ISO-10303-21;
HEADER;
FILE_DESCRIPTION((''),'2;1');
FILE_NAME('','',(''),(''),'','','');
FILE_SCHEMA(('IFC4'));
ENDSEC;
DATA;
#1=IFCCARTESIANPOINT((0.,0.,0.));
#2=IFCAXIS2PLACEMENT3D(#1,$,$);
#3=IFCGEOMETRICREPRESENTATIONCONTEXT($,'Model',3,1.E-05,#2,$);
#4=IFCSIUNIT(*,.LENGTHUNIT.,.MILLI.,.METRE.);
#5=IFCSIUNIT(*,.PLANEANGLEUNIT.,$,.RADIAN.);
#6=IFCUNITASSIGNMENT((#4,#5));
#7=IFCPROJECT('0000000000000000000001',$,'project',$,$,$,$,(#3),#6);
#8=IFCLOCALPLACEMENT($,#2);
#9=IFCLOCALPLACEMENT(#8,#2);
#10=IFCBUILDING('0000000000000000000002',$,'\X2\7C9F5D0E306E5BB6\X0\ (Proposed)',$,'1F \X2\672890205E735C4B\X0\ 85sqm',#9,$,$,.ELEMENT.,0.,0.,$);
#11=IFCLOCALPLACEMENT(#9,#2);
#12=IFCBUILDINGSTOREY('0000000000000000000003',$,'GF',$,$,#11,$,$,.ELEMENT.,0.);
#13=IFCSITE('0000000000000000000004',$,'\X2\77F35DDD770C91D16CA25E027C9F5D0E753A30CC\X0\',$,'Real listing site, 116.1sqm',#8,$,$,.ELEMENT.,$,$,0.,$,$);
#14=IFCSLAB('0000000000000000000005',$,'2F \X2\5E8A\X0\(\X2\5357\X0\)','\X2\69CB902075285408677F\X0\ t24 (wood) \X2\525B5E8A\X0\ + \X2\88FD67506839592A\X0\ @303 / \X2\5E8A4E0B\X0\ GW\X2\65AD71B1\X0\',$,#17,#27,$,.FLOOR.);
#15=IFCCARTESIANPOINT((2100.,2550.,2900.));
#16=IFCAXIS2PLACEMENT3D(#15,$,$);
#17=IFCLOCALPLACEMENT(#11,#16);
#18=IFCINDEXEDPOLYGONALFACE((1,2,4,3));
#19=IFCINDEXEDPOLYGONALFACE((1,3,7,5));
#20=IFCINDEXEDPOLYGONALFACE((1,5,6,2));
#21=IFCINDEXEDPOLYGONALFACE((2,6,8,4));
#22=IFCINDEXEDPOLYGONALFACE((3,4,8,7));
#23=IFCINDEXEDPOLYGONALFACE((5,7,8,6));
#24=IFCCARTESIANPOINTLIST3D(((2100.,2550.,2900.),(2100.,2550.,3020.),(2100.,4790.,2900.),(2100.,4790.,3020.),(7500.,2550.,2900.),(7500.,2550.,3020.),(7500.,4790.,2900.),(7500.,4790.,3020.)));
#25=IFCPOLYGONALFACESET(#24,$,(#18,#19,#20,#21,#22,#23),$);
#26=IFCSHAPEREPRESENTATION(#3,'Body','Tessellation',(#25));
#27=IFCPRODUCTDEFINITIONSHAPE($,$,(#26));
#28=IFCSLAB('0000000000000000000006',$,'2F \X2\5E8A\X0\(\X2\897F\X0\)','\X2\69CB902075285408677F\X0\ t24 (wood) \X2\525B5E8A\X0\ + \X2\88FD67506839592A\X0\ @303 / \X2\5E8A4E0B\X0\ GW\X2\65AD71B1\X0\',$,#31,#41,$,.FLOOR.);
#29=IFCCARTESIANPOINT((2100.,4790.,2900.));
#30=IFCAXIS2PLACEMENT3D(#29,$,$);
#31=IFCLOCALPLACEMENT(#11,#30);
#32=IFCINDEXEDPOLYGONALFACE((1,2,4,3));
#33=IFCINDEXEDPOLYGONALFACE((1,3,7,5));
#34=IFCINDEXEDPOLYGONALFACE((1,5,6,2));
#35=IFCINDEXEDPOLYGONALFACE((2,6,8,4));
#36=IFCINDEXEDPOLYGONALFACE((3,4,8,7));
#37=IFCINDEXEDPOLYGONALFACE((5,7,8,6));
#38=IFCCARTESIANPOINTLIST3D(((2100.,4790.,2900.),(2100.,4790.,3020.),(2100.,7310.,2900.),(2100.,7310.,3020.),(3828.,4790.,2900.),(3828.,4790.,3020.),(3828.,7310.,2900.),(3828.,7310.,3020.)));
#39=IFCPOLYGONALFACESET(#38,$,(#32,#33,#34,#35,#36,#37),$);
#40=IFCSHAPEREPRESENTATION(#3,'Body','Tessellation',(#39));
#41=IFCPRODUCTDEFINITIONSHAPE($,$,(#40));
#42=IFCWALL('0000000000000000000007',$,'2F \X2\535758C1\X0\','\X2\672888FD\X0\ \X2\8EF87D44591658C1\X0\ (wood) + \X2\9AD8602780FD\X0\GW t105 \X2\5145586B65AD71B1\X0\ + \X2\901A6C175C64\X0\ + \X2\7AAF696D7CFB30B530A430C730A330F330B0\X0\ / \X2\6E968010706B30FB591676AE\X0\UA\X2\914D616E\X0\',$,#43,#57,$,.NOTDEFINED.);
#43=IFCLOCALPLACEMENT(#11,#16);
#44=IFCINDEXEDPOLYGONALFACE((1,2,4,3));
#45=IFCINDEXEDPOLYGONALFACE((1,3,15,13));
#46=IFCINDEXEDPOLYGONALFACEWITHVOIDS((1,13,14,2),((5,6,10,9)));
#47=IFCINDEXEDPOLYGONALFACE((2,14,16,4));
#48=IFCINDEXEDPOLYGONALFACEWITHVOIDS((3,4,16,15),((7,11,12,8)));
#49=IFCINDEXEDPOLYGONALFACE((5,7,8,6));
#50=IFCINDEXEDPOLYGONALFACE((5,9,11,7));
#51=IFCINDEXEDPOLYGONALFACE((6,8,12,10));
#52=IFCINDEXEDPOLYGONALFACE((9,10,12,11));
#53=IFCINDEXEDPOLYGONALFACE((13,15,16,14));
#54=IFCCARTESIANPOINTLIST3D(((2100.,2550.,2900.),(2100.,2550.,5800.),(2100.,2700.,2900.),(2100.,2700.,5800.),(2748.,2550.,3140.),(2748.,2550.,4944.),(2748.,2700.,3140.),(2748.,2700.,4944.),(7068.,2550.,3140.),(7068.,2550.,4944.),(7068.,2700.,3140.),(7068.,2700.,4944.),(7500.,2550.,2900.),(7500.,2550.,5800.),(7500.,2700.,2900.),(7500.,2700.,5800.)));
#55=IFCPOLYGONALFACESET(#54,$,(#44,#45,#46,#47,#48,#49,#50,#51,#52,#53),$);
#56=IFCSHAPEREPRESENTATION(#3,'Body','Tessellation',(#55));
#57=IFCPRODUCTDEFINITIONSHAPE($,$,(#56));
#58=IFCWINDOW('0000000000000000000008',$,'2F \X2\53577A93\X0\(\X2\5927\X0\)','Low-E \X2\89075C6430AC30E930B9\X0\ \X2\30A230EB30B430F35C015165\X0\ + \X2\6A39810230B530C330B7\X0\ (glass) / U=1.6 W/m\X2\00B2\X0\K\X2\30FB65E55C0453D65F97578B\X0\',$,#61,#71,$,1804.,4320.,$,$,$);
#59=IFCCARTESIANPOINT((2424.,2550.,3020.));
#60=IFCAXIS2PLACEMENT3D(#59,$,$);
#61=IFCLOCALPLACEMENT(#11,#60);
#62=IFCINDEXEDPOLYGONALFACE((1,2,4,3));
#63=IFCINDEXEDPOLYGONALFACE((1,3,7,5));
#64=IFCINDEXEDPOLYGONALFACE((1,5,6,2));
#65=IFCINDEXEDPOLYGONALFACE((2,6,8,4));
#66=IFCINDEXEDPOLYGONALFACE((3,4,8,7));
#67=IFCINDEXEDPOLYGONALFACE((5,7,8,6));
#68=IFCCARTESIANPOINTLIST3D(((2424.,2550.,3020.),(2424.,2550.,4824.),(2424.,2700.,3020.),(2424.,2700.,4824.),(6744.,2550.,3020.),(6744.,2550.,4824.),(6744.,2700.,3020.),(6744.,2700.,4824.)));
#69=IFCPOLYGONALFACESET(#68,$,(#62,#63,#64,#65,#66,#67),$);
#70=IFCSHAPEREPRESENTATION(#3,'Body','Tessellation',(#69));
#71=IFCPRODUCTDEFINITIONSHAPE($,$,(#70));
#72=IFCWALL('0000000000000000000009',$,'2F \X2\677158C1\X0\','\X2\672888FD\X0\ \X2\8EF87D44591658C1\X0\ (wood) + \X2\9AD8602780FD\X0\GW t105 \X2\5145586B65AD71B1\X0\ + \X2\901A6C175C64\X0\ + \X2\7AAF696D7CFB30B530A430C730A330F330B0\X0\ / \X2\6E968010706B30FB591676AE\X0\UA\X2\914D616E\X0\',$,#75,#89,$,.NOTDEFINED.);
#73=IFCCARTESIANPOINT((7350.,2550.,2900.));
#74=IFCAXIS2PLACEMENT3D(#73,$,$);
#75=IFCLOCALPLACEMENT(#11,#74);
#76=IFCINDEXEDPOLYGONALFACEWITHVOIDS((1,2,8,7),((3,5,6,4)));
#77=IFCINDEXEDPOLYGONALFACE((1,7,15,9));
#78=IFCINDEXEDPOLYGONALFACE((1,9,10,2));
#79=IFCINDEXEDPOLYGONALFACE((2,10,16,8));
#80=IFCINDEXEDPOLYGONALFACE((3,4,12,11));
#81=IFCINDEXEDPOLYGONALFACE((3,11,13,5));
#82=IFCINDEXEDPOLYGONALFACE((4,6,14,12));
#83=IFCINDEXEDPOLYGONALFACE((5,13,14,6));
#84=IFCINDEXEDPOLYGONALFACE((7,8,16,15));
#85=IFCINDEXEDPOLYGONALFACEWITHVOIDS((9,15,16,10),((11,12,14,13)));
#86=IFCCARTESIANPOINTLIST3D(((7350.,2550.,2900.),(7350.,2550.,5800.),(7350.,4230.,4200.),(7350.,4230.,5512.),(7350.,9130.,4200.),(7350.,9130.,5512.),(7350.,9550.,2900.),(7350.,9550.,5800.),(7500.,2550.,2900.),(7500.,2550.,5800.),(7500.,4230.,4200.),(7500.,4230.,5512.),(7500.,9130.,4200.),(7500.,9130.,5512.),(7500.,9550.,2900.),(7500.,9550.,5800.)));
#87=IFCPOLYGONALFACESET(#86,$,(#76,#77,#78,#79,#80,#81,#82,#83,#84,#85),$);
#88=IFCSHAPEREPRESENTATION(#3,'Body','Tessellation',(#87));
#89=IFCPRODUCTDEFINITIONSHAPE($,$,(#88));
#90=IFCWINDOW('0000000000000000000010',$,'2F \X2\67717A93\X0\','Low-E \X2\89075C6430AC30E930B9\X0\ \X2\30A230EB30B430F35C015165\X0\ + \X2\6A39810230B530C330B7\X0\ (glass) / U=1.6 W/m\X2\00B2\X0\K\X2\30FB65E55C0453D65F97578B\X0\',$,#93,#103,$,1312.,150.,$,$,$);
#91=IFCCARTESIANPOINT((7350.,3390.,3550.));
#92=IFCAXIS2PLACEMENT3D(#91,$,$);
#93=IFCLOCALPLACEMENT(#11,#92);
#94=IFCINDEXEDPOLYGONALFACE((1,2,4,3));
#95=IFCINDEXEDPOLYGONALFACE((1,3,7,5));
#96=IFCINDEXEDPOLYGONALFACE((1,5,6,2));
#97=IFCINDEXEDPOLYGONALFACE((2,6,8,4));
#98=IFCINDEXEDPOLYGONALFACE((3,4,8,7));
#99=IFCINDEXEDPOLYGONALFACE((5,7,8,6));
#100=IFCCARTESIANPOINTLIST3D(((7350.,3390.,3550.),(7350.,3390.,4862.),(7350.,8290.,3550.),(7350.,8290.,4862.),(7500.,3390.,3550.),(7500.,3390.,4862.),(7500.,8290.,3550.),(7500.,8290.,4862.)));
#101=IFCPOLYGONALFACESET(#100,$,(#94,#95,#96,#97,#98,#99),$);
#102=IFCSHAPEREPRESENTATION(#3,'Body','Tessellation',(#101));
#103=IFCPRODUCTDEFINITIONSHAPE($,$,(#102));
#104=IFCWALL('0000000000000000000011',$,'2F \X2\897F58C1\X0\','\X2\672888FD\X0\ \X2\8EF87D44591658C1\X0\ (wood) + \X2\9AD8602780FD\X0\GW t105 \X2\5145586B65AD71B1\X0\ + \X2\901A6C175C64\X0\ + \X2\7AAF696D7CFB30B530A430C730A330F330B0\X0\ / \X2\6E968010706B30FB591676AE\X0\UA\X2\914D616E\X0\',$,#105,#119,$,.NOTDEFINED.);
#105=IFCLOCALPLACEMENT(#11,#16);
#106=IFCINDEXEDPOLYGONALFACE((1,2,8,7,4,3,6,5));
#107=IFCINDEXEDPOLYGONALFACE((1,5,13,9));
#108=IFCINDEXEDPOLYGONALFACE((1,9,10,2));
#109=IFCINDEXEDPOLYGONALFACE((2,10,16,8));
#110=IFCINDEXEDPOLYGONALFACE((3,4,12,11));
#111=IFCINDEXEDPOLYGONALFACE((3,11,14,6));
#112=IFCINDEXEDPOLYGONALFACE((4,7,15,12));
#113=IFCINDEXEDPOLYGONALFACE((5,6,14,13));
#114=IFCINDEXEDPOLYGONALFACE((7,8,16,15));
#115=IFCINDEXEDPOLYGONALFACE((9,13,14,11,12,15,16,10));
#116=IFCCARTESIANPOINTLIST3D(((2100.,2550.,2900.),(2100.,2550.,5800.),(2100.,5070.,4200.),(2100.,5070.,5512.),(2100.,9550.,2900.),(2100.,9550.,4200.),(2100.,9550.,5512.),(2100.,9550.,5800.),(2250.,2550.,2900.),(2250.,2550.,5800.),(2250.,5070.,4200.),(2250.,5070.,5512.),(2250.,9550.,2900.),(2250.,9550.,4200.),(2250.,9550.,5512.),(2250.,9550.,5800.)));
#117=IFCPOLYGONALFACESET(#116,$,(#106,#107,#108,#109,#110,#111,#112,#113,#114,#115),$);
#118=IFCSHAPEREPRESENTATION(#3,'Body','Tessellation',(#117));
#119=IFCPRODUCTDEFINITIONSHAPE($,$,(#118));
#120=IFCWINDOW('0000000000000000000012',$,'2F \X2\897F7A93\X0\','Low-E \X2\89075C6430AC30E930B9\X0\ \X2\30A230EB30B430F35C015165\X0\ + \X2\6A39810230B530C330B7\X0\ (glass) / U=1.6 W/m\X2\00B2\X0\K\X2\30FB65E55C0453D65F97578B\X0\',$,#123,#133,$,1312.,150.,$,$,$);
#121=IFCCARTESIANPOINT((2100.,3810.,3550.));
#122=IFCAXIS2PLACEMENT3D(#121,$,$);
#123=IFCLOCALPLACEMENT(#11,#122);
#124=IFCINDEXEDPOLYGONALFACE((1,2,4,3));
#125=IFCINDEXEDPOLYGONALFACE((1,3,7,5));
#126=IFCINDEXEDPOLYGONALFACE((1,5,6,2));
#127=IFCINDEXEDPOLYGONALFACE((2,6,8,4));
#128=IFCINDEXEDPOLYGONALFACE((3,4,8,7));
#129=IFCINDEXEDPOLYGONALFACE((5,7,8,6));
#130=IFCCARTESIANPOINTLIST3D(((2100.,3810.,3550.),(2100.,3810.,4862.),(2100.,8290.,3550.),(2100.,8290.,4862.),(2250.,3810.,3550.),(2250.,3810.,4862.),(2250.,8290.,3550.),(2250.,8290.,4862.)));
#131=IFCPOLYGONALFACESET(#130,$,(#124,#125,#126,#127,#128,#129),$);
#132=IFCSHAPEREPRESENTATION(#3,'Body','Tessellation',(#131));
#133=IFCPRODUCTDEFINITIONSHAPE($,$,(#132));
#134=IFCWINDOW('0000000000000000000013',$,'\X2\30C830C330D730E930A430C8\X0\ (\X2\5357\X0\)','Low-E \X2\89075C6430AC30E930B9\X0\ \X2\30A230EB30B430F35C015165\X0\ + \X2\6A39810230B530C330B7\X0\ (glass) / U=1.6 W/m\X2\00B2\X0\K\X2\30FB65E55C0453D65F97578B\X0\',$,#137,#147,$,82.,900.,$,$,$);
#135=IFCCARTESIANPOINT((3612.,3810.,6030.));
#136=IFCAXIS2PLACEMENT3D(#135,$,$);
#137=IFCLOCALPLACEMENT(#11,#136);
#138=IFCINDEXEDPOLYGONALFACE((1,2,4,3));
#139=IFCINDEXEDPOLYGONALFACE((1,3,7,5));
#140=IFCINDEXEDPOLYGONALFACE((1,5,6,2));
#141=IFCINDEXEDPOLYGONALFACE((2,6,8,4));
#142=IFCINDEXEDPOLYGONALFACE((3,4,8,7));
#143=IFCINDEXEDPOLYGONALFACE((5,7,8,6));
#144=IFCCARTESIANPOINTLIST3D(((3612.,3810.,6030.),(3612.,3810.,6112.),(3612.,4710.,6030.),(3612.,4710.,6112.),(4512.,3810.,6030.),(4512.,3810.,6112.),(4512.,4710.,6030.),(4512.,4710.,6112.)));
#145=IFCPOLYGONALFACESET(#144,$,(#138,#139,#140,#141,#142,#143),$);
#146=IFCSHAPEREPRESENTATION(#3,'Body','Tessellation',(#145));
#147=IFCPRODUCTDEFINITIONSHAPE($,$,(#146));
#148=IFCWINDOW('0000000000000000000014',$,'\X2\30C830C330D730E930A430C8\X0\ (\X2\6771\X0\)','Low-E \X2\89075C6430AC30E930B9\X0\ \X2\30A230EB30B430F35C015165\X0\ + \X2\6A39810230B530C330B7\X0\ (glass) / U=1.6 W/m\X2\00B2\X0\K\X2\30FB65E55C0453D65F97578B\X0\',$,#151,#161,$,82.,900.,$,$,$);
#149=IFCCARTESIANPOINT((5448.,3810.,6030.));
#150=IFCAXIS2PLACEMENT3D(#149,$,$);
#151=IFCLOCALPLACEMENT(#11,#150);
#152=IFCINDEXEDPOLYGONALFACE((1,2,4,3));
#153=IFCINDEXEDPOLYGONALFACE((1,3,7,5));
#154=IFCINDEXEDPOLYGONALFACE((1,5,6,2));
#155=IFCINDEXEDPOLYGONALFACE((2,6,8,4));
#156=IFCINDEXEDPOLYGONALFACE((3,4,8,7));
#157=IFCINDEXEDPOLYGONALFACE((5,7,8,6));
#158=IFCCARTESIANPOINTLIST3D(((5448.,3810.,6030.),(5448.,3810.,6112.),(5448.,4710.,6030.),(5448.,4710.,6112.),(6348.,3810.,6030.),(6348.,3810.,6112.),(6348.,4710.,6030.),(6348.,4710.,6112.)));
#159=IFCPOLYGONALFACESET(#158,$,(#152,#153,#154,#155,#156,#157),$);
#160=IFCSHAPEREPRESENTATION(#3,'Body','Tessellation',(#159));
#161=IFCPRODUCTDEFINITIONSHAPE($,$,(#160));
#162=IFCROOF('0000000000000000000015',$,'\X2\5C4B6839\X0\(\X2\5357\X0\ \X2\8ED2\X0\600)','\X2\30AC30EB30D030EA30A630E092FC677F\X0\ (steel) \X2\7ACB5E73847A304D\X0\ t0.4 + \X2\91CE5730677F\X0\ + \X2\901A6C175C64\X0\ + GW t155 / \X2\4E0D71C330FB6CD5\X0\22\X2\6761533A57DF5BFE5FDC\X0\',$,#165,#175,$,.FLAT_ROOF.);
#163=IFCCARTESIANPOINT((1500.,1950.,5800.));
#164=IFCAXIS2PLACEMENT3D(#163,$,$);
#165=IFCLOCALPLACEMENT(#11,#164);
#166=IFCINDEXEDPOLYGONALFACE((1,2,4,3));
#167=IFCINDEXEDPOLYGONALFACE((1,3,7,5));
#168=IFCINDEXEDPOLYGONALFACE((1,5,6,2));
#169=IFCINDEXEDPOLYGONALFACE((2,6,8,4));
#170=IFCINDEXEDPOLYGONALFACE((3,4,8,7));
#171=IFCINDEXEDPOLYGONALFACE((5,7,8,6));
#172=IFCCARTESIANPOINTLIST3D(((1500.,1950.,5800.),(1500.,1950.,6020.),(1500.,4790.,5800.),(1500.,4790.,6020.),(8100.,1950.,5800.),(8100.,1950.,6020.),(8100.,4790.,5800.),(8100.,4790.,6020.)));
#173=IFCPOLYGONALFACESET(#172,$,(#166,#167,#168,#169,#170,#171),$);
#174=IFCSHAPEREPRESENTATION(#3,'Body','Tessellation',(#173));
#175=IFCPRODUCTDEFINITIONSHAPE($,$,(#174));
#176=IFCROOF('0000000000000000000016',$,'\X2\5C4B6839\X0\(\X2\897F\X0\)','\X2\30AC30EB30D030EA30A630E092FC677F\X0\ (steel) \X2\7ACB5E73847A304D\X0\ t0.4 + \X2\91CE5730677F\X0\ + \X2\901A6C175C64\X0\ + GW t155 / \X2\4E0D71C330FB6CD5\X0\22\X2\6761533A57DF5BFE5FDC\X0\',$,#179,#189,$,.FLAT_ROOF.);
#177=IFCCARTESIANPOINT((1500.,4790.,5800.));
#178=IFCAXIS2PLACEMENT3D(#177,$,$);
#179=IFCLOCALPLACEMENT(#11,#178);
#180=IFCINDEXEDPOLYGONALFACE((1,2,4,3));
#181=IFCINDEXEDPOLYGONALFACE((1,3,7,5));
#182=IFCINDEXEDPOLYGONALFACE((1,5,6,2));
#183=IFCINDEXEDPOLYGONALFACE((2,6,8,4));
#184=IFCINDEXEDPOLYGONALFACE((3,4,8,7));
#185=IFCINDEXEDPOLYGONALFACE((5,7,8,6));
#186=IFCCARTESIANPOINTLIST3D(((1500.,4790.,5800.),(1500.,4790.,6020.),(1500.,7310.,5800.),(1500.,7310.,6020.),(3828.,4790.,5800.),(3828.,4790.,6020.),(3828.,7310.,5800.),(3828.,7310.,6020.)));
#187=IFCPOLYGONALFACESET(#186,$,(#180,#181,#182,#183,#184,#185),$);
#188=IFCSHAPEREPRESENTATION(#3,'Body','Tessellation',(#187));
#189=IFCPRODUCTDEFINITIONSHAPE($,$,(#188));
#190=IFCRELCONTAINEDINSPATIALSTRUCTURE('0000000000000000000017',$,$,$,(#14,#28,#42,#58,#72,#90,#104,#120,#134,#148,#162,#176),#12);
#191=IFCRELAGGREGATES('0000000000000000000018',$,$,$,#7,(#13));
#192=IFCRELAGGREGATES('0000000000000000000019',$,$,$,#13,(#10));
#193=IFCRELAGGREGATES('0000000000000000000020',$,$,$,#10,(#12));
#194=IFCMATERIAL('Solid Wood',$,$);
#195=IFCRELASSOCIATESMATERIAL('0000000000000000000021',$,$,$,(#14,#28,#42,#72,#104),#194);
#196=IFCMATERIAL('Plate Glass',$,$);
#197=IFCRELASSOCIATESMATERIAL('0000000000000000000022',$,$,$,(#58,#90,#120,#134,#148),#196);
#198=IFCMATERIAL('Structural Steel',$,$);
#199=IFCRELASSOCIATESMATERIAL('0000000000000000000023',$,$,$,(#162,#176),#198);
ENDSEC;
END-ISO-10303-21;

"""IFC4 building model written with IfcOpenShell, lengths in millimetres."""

from ifc_helpers import new_model, si_unit, frame, frame_2d, origin, place, context, project, spatial, rectangle, extrude, material, element, fill, save


model = new_model("IFC4")

# Units and contexts
model_context = context("Model", 3, precision=1e-05, world=origin())
ifc_project = project(units=[si_unit("LENGTHUNIT", "METRE", prefix="MILLI"), si_unit("PLANEANGLEUNIT", "RADIAN")], contexts=[model_context])

# Site, building, storey
site_placement = place(None, origin())
site = spatial("IfcSite", under=ifc_project, at=site_placement, Name="石川県金沢市粟崎町ヌ", ObjectType="Real listing site, 116.1sqm", CompositionType="ELEMENT", RefElevation=0.0)
building_placement = place(site_placement, origin())
building = spatial("IfcBuilding", under=site, at=building_placement, Name="粟崎の家 (Proposed)", ObjectType="1F 木造平屋 85sqm", CompositionType="ELEMENT", ElevationOfRefHeight=0.0, ElevationOfTerrain=0.0)
storey_placement = place(building_placement, origin())
storey = spatial("IfcBuildingStorey", under=building, at=storey_placement, Name="GF", CompositionType="ELEMENT", Elevation=0.0)

# Slabs
ifc_material_1 = material(Name="Solid Wood")
slab_1_placement = place(storey_placement, frame((2100.0, 2550.0, 2900.0)))
element("IfcSlab", 1, at=slab_1_placement, inside=storey, material=ifc_material_1, Name="2F 床(南)", Description="構造用合板 t24 (wood) 剛床 + 製材根太 @303 / 床下 GW断熱", PredefinedType="FLOOR", context=model_context, shape_type="SweptSolid", body=[
    extrude(rectangle(XDim=5400.0, YDim=2240.0, at=frame_2d((2700.0, 1120.0))), frame((2100.0, 2550.0, 2900.0)), (0.0, 0.0, 1.0), 120.0),
])
slab_2_placement = place(storey_placement, frame((2100.0, 4790.0, 2900.0)))
element("IfcSlab", 2, at=slab_2_placement, inside=storey, material=ifc_material_1, Name="2F 床(西)", Description="構造用合板 t24 (wood) 剛床 + 製材根太 @303 / 床下 GW断熱", PredefinedType="FLOOR", context=model_context, shape_type="SweptSolid", body=[
    extrude(rectangle(XDim=1728.0, YDim=2520.0, at=frame_2d((864.0, 1260.0))), frame((2100.0, 4790.0, 2900.0)), (0.0, 0.0, 1.0), 120.0),
])

# Walls, openings, windows
wall_1_placement = place(storey_placement, frame((2100.0, 2550.0, 2900.0)))
wall_1 = element("IfcWall", 3, at=wall_1_placement, inside=storey, material=ifc_material_1, Name="2F 南壁", Description="木製 軸組外壁 (wood) + 高性能GW t105 充填断熱 + 通気層 + 窯業系サイディング / 準耐火・外皮UA配慮", PredefinedType="NOTDEFINED", context=model_context, shape_type="SweptSolid", body=[
    extrude(rectangle(XDim=5400.0, YDim=150.0, at=frame_2d((2700.0, 75.0))), frame((2100.0, 2550.0, 2900.0)), (0.0, 0.0, 1.0), 2900.0),
])
opening_1_placement = place(storey_placement, frame((2424.0, 2550.0, 3020.0)))
opening_1 = element("IfcOpeningElement", 4, at=opening_1_placement, cuts=wall_1, PredefinedType="NOTDEFINED", context=model_context, shape_type="SweptSolid", body=[
    extrude(rectangle(XDim=4320.0, YDim=150.0, at=frame_2d((2160.0, 75.0))), frame((2424.0, 2550.0, 3020.0)), (0.0, 0.0, 1.0), 1804.0),
])
ifc_material_2 = material(Name="Plate Glass")
window_1_placement = place(storey_placement, frame((2424.0, 2550.0, 3020.0)))
window_1 = element("IfcWindow", 5, at=window_1_placement, inside=storey, material=ifc_material_2, Name="2F 南窓(大)", Description="Low-E 複層ガラス アルゴン封入 + 樹脂サッシ (glass) / U=1.6 W/m²K・日射取得型", OverallHeight=1804.0, OverallWidth=4320.0, context=model_context, shape_type="SweptSolid", body=[
    extrude(rectangle(XDim=4320.0, YDim=150.0, at=frame_2d((2160.0, 75.0))), frame((2424.0, 2550.0, 3020.0)), (0.0, 0.0, 1.0), 1804.0),
])
fill(opening_1, window_1)
wall_2_placement = place(storey_placement, frame((7350.0, 2550.0, 2900.0)))
wall_2 = element("IfcWall", 6, at=wall_2_placement, inside=storey, material=ifc_material_1, Name="2F 東壁", Description="木製 軸組外壁 (wood) + 高性能GW t105 充填断熱 + 通気層 + 窯業系サイディング / 準耐火・外皮UA配慮", PredefinedType="NOTDEFINED", context=model_context, shape_type="SweptSolid", body=[
    extrude(rectangle(XDim=150.0, YDim=7000.0, at=frame_2d((75.0, 3500.0))), frame((7350.0, 2550.0, 2900.0)), (0.0, 0.0, 1.0), 2900.0),
])
opening_2_placement = place(storey_placement, frame((7350.0, 3390.0, 3550.0)))
opening_2 = element("IfcOpeningElement", 7, at=opening_2_placement, cuts=wall_2, PredefinedType="NOTDEFINED", context=model_context, shape_type="SweptSolid", body=[
    extrude(rectangle(XDim=150.0, YDim=4900.0, at=frame_2d((75.0, 2450.0))), frame((7350.0, 3390.0, 3550.0)), (0.0, 0.0, 1.0), 1312.0),
])
window_2_placement = place(storey_placement, frame((7350.0, 3390.0, 3550.0)))
window_2 = element("IfcWindow", 8, at=window_2_placement, inside=storey, material=ifc_material_2, Name="2F 東窓", Description="Low-E 複層ガラス アルゴン封入 + 樹脂サッシ (glass) / U=1.6 W/m²K・日射取得型", OverallHeight=1312.0, OverallWidth=150.0, context=model_context, shape_type="SweptSolid", body=[
    extrude(rectangle(XDim=150.0, YDim=4900.0, at=frame_2d((75.0, 2450.0))), frame((7350.0, 3390.0, 3550.0)), (0.0, 0.0, 1.0), 1312.0),
])
fill(opening_2, window_2)
wall_3_placement = place(storey_placement, frame((2100.0, 2550.0, 2900.0)))
wall_3 = element("IfcWall", 9, at=wall_3_placement, inside=storey, material=ifc_material_1, Name="2F 西壁", Description="木製 軸組外壁 (wood) + 高性能GW t105 充填断熱 + 通気層 + 窯業系サイディング / 準耐火・外皮UA配慮", PredefinedType="NOTDEFINED", context=model_context, shape_type="SweptSolid", body=[
    extrude(rectangle(XDim=150.0, YDim=7000.0, at=frame_2d((75.0, 3500.0))), frame((2100.0, 2550.0, 2900.0)), (0.0, 0.0, 1.0), 2900.0),
])
opening_3_placement = place(storey_placement, frame((2100.0, 3810.0, 3550.0)))
opening_3 = element("IfcOpeningElement", 10, at=opening_3_placement, cuts=wall_3, PredefinedType="NOTDEFINED", context=model_context, shape_type="SweptSolid", body=[
    extrude(rectangle(XDim=150.0, YDim=4480.0, at=frame_2d((75.0, 2240.0))), frame((2100.0, 3810.0, 3550.0)), (0.0, 0.0, 1.0), 1312.0),
])
window_3_placement = place(storey_placement, frame((2100.0, 3810.0, 3550.0)))
window_3 = element("IfcWindow", 11, at=window_3_placement, inside=storey, material=ifc_material_2, Name="2F 西窓", Description="Low-E 複層ガラス アルゴン封入 + 樹脂サッシ (glass) / U=1.6 W/m²K・日射取得型", OverallHeight=1312.0, OverallWidth=150.0, context=model_context, shape_type="SweptSolid", body=[
    extrude(rectangle(XDim=150.0, YDim=4480.0, at=frame_2d((75.0, 2240.0))), frame((2100.0, 3810.0, 3550.0)), (0.0, 0.0, 1.0), 1312.0),
])
fill(opening_3, window_3)

# Windows
window_4_placement = place(storey_placement, frame((3612.0, 3810.0, 6030.0)))
element("IfcWindow", 12, at=window_4_placement, inside=storey, material=ifc_material_2, Name="トップライト (南)", Description="Low-E 複層ガラス アルゴン封入 + 樹脂サッシ (glass) / U=1.6 W/m²K・日射取得型", OverallHeight=82.0, OverallWidth=900.0, context=model_context, shape_type="SweptSolid", body=[
    extrude(rectangle(XDim=900.0, YDim=900.0, at=frame_2d((450.0, 450.0))), frame((3612.0, 3810.0, 6030.0)), (0.0, 0.0, 1.0), 82.0),
])
window_5_placement = place(storey_placement, frame((5448.0, 3810.0, 6030.0)))
element("IfcWindow", 13, at=window_5_placement, inside=storey, material=ifc_material_2, Name="トップライト (東)", Description="Low-E 複層ガラス アルゴン封入 + 樹脂サッシ (glass) / U=1.6 W/m²K・日射取得型", OverallHeight=82.0, OverallWidth=900.0, context=model_context, shape_type="SweptSolid", body=[
    extrude(rectangle(XDim=900.0, YDim=900.0, at=frame_2d((450.0, 450.0))), frame((5448.0, 3810.0, 6030.0)), (0.0, 0.0, 1.0), 82.0),
])

# Roofs
ifc_material_3 = material(Name="Structural Steel")
roof_1_placement = place(storey_placement, frame((1500.0, 1950.0, 5800.0)))
element("IfcRoof", 14, at=roof_1_placement, inside=storey, material=ifc_material_3, Name="屋根(南 軒600)", Description="ガルバリウム鋼板 (steel) 立平葺き t0.4 + 野地板 + 通気層 + GW t155 / 不燃・法22条区域対応", PredefinedType="FLAT_ROOF", context=model_context, shape_type="SweptSolid", body=[
    extrude(rectangle(XDim=6600.0, YDim=2840.0, at=frame_2d((3300.0, 1420.0))), frame((1500.0, 1950.0, 5800.0)), (0.0, 0.0, 1.0), 220.0),
])
roof_2_placement = place(storey_placement, frame((1500.0, 4790.0, 5800.0)))
element("IfcRoof", 15, at=roof_2_placement, inside=storey, material=ifc_material_3, Name="屋根(西)", Description="ガルバリウム鋼板 (steel) 立平葺き t0.4 + 野地板 + 通気層 + GW t155 / 不燃・法22条区域対応", PredefinedType="FLAT_ROOF", context=model_context, shape_type="SweptSolid", body=[
    extrude(rectangle(XDim=2328.0, YDim=2520.0, at=frame_2d((1164.0, 1260.0))), frame((1500.0, 4790.0, 5800.0)), (0.0, 0.0, 1.0), 220.0),
])

save(model, "model.ifc")
